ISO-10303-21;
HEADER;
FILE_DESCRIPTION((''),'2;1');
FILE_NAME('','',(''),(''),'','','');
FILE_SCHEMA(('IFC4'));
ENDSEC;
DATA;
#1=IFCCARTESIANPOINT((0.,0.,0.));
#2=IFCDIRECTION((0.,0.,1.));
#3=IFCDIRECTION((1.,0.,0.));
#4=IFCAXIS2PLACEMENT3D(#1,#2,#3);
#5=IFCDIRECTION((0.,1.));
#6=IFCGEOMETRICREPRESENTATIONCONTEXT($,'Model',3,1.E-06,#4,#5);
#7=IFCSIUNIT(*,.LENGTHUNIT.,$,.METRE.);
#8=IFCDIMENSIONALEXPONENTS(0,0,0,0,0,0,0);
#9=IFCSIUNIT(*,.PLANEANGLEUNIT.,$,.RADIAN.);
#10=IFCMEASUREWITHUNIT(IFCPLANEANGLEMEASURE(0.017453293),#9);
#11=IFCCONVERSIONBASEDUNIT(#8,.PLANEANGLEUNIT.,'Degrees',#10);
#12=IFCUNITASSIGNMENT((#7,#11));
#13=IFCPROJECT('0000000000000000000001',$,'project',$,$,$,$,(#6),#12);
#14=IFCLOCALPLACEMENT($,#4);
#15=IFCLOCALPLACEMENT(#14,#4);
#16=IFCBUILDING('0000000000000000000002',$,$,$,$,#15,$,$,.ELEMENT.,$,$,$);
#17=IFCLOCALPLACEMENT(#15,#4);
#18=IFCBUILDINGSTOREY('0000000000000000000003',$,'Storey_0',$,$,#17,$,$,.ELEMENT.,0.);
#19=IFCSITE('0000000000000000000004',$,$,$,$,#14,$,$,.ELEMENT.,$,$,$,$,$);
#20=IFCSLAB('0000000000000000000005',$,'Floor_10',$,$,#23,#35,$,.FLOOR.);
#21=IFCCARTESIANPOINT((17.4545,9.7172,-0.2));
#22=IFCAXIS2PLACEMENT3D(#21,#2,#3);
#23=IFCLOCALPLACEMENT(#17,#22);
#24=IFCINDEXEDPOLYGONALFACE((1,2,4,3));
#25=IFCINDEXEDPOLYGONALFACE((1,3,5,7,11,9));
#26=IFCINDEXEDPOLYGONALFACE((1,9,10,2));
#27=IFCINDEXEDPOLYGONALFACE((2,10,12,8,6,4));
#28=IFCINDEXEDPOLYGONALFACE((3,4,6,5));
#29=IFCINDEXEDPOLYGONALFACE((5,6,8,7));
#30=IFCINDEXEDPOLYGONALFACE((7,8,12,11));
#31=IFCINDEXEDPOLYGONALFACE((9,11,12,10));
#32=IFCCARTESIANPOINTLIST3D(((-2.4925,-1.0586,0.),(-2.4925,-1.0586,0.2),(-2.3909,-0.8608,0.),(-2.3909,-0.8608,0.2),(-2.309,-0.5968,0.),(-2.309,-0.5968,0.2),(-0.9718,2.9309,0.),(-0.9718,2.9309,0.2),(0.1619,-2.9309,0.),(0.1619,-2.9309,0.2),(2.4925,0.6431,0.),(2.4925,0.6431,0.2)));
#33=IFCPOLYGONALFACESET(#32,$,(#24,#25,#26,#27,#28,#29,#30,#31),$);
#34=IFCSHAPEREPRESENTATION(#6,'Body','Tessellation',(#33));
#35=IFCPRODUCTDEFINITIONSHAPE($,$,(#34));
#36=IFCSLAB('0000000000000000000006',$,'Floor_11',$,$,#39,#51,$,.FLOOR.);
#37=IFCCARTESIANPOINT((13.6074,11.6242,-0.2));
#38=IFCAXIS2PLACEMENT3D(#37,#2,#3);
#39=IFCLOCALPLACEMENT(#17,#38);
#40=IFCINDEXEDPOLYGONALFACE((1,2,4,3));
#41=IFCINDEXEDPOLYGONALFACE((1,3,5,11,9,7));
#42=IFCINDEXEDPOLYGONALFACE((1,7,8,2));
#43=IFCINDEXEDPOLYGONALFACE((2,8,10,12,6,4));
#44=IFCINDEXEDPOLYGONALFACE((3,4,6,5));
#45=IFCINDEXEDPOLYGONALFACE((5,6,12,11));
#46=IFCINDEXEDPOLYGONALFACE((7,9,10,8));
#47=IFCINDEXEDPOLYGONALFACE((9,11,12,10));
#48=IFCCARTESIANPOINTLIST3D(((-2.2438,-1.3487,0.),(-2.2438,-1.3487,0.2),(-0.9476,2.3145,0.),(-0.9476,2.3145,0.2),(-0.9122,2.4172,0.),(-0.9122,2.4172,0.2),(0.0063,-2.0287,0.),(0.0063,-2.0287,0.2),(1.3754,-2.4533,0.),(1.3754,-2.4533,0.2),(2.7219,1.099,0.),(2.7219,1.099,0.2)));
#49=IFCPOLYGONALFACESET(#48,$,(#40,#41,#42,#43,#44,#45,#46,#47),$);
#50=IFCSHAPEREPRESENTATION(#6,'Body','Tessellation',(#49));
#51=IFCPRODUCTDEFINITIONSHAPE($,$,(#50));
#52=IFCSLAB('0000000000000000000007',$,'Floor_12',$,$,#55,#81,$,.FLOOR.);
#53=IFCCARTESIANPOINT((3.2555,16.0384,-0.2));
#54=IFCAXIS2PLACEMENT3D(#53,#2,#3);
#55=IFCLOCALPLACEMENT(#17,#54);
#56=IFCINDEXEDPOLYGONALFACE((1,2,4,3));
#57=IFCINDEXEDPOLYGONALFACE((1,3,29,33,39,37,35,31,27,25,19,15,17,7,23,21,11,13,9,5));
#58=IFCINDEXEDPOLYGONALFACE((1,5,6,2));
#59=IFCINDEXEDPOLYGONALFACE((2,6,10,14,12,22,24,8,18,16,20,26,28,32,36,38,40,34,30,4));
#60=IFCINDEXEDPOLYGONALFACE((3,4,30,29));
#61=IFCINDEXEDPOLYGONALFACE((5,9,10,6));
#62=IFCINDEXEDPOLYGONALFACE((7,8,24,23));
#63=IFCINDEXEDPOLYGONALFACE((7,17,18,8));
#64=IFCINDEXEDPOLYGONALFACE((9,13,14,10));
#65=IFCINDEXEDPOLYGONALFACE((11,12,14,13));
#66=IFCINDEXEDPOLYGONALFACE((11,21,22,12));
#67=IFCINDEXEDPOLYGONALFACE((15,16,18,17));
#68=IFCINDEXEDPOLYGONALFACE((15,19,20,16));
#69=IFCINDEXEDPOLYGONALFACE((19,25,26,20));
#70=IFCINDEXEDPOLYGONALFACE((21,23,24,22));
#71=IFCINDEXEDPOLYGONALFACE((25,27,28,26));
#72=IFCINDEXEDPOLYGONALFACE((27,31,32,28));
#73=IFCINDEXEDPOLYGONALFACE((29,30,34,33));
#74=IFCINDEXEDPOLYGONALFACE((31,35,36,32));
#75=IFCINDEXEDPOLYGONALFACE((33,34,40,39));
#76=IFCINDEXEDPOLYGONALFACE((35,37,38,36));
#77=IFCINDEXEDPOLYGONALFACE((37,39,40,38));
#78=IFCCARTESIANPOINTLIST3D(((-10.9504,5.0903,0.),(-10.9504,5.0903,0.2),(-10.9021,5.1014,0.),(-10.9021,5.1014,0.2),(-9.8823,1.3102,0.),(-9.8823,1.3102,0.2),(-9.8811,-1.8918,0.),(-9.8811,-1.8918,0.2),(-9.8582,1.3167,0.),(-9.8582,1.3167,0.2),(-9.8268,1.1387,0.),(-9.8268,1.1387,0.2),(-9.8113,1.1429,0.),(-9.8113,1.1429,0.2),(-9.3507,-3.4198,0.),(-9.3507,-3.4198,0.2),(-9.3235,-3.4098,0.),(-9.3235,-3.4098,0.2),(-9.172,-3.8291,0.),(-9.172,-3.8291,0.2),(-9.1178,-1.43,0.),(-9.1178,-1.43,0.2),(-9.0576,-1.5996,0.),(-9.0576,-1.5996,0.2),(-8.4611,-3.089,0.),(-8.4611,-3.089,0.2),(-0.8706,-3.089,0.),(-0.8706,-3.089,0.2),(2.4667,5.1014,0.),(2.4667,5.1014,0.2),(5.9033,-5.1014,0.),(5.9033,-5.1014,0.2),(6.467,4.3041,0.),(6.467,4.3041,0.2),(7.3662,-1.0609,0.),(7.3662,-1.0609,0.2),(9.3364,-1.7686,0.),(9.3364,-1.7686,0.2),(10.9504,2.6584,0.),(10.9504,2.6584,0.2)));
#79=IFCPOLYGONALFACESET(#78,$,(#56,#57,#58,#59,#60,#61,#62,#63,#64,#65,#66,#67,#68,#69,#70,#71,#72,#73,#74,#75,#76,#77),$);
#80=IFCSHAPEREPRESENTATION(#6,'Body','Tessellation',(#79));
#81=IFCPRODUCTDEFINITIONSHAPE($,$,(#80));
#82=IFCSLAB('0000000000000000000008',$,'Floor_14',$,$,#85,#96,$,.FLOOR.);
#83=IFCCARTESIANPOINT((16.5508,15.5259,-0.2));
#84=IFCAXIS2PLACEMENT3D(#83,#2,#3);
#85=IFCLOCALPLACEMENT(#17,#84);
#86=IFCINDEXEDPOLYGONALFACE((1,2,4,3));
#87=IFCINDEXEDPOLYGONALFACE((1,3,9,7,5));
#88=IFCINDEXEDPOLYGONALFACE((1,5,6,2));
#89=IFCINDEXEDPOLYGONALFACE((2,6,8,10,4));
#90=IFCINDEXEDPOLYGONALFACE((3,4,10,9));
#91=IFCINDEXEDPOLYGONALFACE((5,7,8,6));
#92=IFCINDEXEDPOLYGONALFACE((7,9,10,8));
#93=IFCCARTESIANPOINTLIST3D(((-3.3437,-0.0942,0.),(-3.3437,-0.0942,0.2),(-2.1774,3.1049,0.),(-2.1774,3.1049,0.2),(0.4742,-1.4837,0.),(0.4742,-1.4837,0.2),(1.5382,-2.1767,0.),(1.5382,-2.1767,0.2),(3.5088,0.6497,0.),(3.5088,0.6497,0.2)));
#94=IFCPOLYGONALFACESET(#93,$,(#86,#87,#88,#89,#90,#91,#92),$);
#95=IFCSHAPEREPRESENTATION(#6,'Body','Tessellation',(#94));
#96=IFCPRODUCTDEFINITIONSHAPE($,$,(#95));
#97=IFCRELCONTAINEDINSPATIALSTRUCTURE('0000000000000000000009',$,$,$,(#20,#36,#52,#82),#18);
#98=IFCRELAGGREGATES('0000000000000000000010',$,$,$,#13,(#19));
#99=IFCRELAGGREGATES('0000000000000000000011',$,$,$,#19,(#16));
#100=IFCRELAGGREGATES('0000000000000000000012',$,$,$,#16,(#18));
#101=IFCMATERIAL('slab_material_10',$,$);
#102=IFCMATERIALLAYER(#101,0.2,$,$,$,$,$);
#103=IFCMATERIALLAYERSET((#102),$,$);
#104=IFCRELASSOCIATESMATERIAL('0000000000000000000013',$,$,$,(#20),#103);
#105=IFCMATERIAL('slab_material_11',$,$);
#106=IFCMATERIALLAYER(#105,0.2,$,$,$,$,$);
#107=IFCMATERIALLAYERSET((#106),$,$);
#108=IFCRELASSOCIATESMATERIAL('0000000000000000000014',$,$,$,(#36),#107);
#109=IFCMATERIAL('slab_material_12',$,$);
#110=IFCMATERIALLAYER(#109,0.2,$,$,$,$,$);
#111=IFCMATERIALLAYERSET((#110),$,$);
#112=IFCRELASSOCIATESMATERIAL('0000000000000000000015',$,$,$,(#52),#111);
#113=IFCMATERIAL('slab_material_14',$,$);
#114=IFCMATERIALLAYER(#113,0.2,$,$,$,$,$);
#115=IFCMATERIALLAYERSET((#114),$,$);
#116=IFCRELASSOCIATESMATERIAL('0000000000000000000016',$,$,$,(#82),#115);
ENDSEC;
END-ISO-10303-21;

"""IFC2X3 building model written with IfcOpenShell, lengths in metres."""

from ifc_helpers import new_model, entity, si_unit, converted_unit, direction, frame, origin_with_axes, place, context, project, spatial, polyline, outline, extrude, material, layer, layer_set, layer_usage, element, save


model = new_model("IFC2X3")

# Units and contexts
model_context = context("Model", 3, precision=1e-06, world=origin_with_axes(), true_north=direction((0.0, 1.0)))
ifc_project = project(units=[si_unit("LENGTHUNIT", "METRE"), converted_unit("PLANEANGLEUNIT", "Degrees", entity("IfcPlaneAngleMeasure", 0.017453293), si_unit("PLANEANGLEUNIT", "RADIAN"), dimensions=[0, 0, 0, 0, 0, 0, 0])], contexts=[model_context])

# Site, building, storey
site_placement = place(None, origin_with_axes())
site = spatial("IfcSite", under=ifc_project, at=site_placement, CompositionType="ELEMENT")
building_placement = place(site_placement, origin_with_axes())
building = spatial("IfcBuilding", under=site, at=building_placement, CompositionType="ELEMENT")
storey_placement = place(building_placement, origin_with_axes())
storey = spatial("IfcBuildingStorey", under=building, at=storey_placement, Name="Storey_0", CompositionType="ELEMENT", Elevation=0.0)

# Slabs
ifc_material_1 = material(Name="slab_material_10")
ifc_layer_1 = layer(ifc_material_1, 0.2)
ifc_layer_set_1 = layer_set([ifc_layer_1])
ifc_layer_usage_1 = layer_usage(ifc_layer_set_1, "AXIS3", "POSITIVE", 0.0)
slab_1_placement = place(storey_placement, frame((17.4545, 9.7172, -0.2), z_axis=(0.0, 0.0, 1.0), x_axis=(1.0, 0.0, 0.0)))
element("IfcSlab", 1, at=slab_1_placement, inside=storey, material=ifc_layer_usage_1, Name="Floor_10", PredefinedType="FLOOR", context=model_context, shape_type="SweptSolid", body=[
    extrude(outline(polyline([(2.4925, 0.6431), (0.1619, -2.9309), (-2.4925, -1.0586), (-2.3909, -0.8608), (-2.309, -0.5968), (-0.9718, 2.9309), (2.4925, 0.6431)])), origin_with_axes(), (0.0, 0.0, 1.0), 0.2),
])
ifc_material_2 = material(Name="slab_material_11")
ifc_layer_2 = layer(ifc_material_2, 0.2)
ifc_layer_set_2 = layer_set([ifc_layer_2])
ifc_layer_usage_2 = layer_usage(ifc_layer_set_2, "AXIS3", "POSITIVE", 0.0)
slab_2_placement = place(storey_placement, frame((13.6074, 11.6242, -0.2), z_axis=(0.0, 0.0, 1.0), x_axis=(1.0, 0.0, 0.0)))
element("IfcSlab", 2, at=slab_2_placement, inside=storey, material=ifc_layer_usage_2, Name="Floor_11", PredefinedType="FLOOR", context=model_context, shape_type="SweptSolid", body=[
    extrude(outline(polyline([(-0.9122, 2.4172), (-0.9476, 2.3145), (-2.2438, -1.3487), (0.0063, -2.0287), (1.3754, -2.4533), (2.7219, 1.099), (-0.9122, 2.4172)])), origin_with_axes(), (0.0, 0.0, 1.0), 0.2),
])
ifc_material_3 = material(Name="slab_material_12")
ifc_layer_3 = layer(ifc_material_3, 0.2)
ifc_layer_set_3 = layer_set([ifc_layer_3])
ifc_layer_usage_3 = layer_usage(ifc_layer_set_3, "AXIS3", "POSITIVE", 0.0)
slab_3_placement = place(storey_placement, frame((3.2555, 16.0384, -0.2), z_axis=(0.0, 0.0, 1.0), x_axis=(1.0, 0.0, 0.0)))
element("IfcSlab", 3, at=slab_3_placement, inside=storey, material=ifc_layer_usage_3, Name="Floor_12", PredefinedType="FLOOR", context=model_context, shape_type="SweptSolid", body=[
    extrude(outline(polyline([(-8.4611, -3.089), (-9.172, -3.8291), (-9.3507, -3.4198), (-9.3235, -3.4098), (-9.8811, -1.8918), (-9.0576, -1.5996), (-9.1178, -1.43), (-9.8268, 1.1387), (-9.8113, 1.1429), (-9.8582, 1.3167), (-9.8823, 1.3102), (-10.9504, 5.0903), (-10.9021, 5.1014), (2.4667, 5.1014), (6.467, 4.3041), (10.9504, 2.6584), (9.3364, -1.7686), (7.3662, -1.0609), (5.9033, -5.1014), (-0.8706, -3.089), (-8.4611, -3.089)])), origin_with_axes(), (0.0, 0.0, 1.0), 0.2),
])
ifc_material_4 = material(Name="slab_material_14")
ifc_layer_4 = layer(ifc_material_4, 0.2)
ifc_layer_set_4 = layer_set([ifc_layer_4])
ifc_layer_usage_4 = layer_usage(ifc_layer_set_4, "AXIS3", "POSITIVE", 0.0)
slab_4_placement = place(storey_placement, frame((16.5508, 15.5259, -0.2), z_axis=(0.0, 0.0, 1.0), x_axis=(1.0, 0.0, 0.0)))
element("IfcSlab", 4, at=slab_4_placement, inside=storey, material=ifc_layer_usage_4, Name="Floor_14", PredefinedType="FLOOR", context=model_context, shape_type="SweptSolid", body=[
    extrude(outline(polyline([(-2.1774, 3.1049), (-3.3437, -0.0942), (0.4742, -1.4837), (1.5382, -2.1767), (3.5088, 0.6497), (-2.1774, 3.1049)])), origin_with_axes(), (0.0, 0.0, 1.0), 0.2),
])

save(model, "model.ifc")
